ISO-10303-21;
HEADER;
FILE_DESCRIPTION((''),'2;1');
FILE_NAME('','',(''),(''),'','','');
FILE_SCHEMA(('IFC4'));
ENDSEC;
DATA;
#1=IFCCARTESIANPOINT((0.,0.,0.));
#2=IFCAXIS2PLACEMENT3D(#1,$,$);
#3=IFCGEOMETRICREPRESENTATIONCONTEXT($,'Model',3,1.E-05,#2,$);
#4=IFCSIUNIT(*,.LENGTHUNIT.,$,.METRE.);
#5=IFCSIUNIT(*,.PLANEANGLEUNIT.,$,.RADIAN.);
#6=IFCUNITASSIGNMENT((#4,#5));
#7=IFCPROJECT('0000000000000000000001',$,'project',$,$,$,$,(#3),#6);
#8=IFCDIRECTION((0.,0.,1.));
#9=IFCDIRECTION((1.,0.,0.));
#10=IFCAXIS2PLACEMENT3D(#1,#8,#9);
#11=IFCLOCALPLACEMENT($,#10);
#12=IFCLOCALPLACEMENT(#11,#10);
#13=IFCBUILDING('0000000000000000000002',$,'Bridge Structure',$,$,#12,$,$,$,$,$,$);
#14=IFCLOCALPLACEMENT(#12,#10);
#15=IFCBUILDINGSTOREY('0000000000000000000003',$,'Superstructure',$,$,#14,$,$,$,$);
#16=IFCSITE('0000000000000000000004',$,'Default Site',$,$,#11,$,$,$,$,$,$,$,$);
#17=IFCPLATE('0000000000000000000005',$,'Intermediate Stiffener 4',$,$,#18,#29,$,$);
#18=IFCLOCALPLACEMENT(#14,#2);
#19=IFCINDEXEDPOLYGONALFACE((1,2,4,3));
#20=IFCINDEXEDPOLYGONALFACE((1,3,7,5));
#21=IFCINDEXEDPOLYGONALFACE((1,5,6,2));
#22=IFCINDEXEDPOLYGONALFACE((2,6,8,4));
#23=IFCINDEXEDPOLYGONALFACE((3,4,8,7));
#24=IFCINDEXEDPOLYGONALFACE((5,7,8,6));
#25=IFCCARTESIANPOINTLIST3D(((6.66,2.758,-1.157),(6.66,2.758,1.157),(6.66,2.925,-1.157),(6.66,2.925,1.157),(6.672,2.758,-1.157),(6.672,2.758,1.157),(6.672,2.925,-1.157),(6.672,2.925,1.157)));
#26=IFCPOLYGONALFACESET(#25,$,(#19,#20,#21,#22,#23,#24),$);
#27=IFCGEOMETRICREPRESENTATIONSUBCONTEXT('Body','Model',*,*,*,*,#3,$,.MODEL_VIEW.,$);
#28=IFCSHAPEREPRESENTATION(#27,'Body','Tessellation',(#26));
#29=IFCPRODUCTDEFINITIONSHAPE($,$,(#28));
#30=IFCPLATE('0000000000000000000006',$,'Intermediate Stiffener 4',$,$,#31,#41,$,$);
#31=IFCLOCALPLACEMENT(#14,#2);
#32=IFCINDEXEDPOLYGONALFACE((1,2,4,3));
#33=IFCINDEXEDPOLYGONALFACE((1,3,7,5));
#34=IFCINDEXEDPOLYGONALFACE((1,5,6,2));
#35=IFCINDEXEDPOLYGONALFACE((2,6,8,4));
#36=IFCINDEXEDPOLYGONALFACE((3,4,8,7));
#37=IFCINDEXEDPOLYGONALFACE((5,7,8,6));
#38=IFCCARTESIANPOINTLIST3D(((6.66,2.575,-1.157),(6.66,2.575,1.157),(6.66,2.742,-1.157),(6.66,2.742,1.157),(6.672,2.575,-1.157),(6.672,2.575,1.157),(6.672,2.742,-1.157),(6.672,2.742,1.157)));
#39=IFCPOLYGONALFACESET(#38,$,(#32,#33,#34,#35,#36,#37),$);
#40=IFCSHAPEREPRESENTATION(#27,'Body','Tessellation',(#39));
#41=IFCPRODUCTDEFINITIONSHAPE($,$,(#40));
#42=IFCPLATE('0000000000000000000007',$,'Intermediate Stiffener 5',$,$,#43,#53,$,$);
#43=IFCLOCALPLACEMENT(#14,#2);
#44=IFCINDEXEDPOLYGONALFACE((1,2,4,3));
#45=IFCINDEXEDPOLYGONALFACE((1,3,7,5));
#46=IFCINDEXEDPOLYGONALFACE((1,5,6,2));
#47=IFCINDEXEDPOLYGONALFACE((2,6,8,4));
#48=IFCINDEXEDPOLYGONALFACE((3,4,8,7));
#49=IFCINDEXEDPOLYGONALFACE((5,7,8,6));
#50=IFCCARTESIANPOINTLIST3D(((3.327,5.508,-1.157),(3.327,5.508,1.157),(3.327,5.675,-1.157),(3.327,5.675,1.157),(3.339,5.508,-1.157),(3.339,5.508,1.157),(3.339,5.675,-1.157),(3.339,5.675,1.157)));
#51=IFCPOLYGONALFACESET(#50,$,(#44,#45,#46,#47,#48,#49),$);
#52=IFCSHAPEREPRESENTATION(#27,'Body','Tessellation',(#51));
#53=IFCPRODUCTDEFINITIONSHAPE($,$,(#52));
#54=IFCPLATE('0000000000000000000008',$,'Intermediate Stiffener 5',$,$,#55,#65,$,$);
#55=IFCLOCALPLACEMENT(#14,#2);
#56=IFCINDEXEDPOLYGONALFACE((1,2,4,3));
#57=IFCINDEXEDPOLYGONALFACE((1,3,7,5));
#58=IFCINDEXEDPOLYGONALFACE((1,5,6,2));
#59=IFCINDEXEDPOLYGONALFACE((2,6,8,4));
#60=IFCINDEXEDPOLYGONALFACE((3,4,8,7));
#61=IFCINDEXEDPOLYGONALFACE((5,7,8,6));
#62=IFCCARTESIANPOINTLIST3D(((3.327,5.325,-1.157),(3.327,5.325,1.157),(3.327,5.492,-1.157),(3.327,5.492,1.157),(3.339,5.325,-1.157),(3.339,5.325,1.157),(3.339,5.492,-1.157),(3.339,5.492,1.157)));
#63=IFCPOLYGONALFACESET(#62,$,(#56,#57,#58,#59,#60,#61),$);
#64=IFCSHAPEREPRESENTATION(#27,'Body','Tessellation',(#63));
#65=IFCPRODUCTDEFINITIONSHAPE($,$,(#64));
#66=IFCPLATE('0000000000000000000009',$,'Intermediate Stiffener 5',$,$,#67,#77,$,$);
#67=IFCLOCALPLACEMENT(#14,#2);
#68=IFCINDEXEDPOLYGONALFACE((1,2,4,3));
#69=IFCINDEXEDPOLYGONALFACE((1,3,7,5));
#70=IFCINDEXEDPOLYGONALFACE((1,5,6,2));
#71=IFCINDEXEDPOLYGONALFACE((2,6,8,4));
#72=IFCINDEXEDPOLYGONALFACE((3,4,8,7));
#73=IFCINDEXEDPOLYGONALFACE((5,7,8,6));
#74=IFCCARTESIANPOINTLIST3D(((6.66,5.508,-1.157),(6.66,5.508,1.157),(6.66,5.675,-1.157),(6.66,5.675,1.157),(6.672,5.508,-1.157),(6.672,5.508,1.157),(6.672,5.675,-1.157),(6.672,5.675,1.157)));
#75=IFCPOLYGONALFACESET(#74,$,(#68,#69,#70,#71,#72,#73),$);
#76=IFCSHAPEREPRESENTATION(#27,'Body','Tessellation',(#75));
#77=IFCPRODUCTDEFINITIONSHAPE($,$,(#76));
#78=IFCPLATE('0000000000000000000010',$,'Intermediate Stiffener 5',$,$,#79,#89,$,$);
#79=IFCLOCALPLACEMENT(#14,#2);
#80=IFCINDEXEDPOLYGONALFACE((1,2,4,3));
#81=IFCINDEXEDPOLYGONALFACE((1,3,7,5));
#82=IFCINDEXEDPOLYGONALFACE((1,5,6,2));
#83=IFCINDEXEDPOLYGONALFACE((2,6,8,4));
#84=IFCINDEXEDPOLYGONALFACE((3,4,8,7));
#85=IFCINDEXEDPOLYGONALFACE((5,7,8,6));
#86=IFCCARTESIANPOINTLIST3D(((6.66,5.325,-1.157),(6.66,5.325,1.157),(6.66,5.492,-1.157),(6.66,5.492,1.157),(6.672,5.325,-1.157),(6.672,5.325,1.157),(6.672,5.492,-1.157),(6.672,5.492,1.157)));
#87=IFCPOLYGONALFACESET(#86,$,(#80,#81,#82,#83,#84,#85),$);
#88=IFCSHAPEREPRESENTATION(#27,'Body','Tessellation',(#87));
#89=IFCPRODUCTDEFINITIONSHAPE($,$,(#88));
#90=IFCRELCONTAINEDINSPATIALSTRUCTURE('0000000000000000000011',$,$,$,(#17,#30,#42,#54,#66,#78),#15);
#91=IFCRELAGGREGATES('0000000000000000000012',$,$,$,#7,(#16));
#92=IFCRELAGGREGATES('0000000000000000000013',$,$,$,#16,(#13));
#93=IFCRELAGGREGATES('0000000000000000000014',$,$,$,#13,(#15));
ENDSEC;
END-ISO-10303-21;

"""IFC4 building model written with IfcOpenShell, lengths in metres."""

from ifc_helpers import new_model, si_unit, frame, origin, origin_with_axes, origin_2d_with_axis, place, context, subcontext, project, spatial, rectangle, extrude, element, save


model = new_model("IFC4")

# Units and contexts
model_context = context("Model", 3, precision=1e-05, world=origin())
body_context = subcontext(model_context, "Body", "Model", "MODEL_VIEW")
ifc_project = project(units=[si_unit("LENGTHUNIT", "METRE"), si_unit("PLANEANGLEUNIT", "RADIAN")], contexts=[model_context])

# Site, building, storey
site_placement = place(None, origin_with_axes())
site = spatial("IfcSite", under=ifc_project, at=site_placement, Name="Default Site")
building_placement = place(site_placement, origin_with_axes())
building = spatial("IfcBuilding", under=site, at=building_placement, Name="Bridge Structure")
storey_placement = place(building_placement, origin_with_axes())
storey = spatial("IfcBuildingStorey", under=building, at=storey_placement, Name="Superstructure")

# Plates
for number, where, z_axis, x_axis, name in (
    (1, (6.666, 2.8415, -1.157), (0.0, 0.0, 1.0), (1.0, 0.0, 0.0), "Intermediate Stiffener 4"),
    (2, (6.666, 2.6585, -1.157), (0.0, 0.0, 1.0), (1.0, 0.0, 0.0), "Intermediate Stiffener 4"),
    (3, (3.333, 5.5915, -1.157), (0.0, 0.0, 1.0), (1.0, 0.0, 0.0), "Intermediate Stiffener 5"),
    (4, (3.333, 5.4085, -1.157), (0.0, 0.0, 1.0), (1.0, 0.0, 0.0), "Intermediate Stiffener 5"),
    (5, (6.666, 5.5915, -1.157), (0.0, 0.0, 1.0), (1.0, 0.0, 0.0), "Intermediate Stiffener 5"),
    (6, (6.666, 5.4085, -1.157), (0.0, 0.0, 1.0), (1.0, 0.0, 0.0), "Intermediate Stiffener 5"),
):
    element("IfcPlate", number, at=place(storey_placement, frame(where, z_axis=z_axis, x_axis=x_axis)), inside=storey, Name=name, context=body_context, shape_type="SweptSolid", body=[
        extrude(rectangle(XDim=0.012, YDim=0.167, at=origin_2d_with_axis()), origin_with_axes(), (0.0, 0.0, 1.0), 2.314),
    ])

save(model, "model.ifc")
